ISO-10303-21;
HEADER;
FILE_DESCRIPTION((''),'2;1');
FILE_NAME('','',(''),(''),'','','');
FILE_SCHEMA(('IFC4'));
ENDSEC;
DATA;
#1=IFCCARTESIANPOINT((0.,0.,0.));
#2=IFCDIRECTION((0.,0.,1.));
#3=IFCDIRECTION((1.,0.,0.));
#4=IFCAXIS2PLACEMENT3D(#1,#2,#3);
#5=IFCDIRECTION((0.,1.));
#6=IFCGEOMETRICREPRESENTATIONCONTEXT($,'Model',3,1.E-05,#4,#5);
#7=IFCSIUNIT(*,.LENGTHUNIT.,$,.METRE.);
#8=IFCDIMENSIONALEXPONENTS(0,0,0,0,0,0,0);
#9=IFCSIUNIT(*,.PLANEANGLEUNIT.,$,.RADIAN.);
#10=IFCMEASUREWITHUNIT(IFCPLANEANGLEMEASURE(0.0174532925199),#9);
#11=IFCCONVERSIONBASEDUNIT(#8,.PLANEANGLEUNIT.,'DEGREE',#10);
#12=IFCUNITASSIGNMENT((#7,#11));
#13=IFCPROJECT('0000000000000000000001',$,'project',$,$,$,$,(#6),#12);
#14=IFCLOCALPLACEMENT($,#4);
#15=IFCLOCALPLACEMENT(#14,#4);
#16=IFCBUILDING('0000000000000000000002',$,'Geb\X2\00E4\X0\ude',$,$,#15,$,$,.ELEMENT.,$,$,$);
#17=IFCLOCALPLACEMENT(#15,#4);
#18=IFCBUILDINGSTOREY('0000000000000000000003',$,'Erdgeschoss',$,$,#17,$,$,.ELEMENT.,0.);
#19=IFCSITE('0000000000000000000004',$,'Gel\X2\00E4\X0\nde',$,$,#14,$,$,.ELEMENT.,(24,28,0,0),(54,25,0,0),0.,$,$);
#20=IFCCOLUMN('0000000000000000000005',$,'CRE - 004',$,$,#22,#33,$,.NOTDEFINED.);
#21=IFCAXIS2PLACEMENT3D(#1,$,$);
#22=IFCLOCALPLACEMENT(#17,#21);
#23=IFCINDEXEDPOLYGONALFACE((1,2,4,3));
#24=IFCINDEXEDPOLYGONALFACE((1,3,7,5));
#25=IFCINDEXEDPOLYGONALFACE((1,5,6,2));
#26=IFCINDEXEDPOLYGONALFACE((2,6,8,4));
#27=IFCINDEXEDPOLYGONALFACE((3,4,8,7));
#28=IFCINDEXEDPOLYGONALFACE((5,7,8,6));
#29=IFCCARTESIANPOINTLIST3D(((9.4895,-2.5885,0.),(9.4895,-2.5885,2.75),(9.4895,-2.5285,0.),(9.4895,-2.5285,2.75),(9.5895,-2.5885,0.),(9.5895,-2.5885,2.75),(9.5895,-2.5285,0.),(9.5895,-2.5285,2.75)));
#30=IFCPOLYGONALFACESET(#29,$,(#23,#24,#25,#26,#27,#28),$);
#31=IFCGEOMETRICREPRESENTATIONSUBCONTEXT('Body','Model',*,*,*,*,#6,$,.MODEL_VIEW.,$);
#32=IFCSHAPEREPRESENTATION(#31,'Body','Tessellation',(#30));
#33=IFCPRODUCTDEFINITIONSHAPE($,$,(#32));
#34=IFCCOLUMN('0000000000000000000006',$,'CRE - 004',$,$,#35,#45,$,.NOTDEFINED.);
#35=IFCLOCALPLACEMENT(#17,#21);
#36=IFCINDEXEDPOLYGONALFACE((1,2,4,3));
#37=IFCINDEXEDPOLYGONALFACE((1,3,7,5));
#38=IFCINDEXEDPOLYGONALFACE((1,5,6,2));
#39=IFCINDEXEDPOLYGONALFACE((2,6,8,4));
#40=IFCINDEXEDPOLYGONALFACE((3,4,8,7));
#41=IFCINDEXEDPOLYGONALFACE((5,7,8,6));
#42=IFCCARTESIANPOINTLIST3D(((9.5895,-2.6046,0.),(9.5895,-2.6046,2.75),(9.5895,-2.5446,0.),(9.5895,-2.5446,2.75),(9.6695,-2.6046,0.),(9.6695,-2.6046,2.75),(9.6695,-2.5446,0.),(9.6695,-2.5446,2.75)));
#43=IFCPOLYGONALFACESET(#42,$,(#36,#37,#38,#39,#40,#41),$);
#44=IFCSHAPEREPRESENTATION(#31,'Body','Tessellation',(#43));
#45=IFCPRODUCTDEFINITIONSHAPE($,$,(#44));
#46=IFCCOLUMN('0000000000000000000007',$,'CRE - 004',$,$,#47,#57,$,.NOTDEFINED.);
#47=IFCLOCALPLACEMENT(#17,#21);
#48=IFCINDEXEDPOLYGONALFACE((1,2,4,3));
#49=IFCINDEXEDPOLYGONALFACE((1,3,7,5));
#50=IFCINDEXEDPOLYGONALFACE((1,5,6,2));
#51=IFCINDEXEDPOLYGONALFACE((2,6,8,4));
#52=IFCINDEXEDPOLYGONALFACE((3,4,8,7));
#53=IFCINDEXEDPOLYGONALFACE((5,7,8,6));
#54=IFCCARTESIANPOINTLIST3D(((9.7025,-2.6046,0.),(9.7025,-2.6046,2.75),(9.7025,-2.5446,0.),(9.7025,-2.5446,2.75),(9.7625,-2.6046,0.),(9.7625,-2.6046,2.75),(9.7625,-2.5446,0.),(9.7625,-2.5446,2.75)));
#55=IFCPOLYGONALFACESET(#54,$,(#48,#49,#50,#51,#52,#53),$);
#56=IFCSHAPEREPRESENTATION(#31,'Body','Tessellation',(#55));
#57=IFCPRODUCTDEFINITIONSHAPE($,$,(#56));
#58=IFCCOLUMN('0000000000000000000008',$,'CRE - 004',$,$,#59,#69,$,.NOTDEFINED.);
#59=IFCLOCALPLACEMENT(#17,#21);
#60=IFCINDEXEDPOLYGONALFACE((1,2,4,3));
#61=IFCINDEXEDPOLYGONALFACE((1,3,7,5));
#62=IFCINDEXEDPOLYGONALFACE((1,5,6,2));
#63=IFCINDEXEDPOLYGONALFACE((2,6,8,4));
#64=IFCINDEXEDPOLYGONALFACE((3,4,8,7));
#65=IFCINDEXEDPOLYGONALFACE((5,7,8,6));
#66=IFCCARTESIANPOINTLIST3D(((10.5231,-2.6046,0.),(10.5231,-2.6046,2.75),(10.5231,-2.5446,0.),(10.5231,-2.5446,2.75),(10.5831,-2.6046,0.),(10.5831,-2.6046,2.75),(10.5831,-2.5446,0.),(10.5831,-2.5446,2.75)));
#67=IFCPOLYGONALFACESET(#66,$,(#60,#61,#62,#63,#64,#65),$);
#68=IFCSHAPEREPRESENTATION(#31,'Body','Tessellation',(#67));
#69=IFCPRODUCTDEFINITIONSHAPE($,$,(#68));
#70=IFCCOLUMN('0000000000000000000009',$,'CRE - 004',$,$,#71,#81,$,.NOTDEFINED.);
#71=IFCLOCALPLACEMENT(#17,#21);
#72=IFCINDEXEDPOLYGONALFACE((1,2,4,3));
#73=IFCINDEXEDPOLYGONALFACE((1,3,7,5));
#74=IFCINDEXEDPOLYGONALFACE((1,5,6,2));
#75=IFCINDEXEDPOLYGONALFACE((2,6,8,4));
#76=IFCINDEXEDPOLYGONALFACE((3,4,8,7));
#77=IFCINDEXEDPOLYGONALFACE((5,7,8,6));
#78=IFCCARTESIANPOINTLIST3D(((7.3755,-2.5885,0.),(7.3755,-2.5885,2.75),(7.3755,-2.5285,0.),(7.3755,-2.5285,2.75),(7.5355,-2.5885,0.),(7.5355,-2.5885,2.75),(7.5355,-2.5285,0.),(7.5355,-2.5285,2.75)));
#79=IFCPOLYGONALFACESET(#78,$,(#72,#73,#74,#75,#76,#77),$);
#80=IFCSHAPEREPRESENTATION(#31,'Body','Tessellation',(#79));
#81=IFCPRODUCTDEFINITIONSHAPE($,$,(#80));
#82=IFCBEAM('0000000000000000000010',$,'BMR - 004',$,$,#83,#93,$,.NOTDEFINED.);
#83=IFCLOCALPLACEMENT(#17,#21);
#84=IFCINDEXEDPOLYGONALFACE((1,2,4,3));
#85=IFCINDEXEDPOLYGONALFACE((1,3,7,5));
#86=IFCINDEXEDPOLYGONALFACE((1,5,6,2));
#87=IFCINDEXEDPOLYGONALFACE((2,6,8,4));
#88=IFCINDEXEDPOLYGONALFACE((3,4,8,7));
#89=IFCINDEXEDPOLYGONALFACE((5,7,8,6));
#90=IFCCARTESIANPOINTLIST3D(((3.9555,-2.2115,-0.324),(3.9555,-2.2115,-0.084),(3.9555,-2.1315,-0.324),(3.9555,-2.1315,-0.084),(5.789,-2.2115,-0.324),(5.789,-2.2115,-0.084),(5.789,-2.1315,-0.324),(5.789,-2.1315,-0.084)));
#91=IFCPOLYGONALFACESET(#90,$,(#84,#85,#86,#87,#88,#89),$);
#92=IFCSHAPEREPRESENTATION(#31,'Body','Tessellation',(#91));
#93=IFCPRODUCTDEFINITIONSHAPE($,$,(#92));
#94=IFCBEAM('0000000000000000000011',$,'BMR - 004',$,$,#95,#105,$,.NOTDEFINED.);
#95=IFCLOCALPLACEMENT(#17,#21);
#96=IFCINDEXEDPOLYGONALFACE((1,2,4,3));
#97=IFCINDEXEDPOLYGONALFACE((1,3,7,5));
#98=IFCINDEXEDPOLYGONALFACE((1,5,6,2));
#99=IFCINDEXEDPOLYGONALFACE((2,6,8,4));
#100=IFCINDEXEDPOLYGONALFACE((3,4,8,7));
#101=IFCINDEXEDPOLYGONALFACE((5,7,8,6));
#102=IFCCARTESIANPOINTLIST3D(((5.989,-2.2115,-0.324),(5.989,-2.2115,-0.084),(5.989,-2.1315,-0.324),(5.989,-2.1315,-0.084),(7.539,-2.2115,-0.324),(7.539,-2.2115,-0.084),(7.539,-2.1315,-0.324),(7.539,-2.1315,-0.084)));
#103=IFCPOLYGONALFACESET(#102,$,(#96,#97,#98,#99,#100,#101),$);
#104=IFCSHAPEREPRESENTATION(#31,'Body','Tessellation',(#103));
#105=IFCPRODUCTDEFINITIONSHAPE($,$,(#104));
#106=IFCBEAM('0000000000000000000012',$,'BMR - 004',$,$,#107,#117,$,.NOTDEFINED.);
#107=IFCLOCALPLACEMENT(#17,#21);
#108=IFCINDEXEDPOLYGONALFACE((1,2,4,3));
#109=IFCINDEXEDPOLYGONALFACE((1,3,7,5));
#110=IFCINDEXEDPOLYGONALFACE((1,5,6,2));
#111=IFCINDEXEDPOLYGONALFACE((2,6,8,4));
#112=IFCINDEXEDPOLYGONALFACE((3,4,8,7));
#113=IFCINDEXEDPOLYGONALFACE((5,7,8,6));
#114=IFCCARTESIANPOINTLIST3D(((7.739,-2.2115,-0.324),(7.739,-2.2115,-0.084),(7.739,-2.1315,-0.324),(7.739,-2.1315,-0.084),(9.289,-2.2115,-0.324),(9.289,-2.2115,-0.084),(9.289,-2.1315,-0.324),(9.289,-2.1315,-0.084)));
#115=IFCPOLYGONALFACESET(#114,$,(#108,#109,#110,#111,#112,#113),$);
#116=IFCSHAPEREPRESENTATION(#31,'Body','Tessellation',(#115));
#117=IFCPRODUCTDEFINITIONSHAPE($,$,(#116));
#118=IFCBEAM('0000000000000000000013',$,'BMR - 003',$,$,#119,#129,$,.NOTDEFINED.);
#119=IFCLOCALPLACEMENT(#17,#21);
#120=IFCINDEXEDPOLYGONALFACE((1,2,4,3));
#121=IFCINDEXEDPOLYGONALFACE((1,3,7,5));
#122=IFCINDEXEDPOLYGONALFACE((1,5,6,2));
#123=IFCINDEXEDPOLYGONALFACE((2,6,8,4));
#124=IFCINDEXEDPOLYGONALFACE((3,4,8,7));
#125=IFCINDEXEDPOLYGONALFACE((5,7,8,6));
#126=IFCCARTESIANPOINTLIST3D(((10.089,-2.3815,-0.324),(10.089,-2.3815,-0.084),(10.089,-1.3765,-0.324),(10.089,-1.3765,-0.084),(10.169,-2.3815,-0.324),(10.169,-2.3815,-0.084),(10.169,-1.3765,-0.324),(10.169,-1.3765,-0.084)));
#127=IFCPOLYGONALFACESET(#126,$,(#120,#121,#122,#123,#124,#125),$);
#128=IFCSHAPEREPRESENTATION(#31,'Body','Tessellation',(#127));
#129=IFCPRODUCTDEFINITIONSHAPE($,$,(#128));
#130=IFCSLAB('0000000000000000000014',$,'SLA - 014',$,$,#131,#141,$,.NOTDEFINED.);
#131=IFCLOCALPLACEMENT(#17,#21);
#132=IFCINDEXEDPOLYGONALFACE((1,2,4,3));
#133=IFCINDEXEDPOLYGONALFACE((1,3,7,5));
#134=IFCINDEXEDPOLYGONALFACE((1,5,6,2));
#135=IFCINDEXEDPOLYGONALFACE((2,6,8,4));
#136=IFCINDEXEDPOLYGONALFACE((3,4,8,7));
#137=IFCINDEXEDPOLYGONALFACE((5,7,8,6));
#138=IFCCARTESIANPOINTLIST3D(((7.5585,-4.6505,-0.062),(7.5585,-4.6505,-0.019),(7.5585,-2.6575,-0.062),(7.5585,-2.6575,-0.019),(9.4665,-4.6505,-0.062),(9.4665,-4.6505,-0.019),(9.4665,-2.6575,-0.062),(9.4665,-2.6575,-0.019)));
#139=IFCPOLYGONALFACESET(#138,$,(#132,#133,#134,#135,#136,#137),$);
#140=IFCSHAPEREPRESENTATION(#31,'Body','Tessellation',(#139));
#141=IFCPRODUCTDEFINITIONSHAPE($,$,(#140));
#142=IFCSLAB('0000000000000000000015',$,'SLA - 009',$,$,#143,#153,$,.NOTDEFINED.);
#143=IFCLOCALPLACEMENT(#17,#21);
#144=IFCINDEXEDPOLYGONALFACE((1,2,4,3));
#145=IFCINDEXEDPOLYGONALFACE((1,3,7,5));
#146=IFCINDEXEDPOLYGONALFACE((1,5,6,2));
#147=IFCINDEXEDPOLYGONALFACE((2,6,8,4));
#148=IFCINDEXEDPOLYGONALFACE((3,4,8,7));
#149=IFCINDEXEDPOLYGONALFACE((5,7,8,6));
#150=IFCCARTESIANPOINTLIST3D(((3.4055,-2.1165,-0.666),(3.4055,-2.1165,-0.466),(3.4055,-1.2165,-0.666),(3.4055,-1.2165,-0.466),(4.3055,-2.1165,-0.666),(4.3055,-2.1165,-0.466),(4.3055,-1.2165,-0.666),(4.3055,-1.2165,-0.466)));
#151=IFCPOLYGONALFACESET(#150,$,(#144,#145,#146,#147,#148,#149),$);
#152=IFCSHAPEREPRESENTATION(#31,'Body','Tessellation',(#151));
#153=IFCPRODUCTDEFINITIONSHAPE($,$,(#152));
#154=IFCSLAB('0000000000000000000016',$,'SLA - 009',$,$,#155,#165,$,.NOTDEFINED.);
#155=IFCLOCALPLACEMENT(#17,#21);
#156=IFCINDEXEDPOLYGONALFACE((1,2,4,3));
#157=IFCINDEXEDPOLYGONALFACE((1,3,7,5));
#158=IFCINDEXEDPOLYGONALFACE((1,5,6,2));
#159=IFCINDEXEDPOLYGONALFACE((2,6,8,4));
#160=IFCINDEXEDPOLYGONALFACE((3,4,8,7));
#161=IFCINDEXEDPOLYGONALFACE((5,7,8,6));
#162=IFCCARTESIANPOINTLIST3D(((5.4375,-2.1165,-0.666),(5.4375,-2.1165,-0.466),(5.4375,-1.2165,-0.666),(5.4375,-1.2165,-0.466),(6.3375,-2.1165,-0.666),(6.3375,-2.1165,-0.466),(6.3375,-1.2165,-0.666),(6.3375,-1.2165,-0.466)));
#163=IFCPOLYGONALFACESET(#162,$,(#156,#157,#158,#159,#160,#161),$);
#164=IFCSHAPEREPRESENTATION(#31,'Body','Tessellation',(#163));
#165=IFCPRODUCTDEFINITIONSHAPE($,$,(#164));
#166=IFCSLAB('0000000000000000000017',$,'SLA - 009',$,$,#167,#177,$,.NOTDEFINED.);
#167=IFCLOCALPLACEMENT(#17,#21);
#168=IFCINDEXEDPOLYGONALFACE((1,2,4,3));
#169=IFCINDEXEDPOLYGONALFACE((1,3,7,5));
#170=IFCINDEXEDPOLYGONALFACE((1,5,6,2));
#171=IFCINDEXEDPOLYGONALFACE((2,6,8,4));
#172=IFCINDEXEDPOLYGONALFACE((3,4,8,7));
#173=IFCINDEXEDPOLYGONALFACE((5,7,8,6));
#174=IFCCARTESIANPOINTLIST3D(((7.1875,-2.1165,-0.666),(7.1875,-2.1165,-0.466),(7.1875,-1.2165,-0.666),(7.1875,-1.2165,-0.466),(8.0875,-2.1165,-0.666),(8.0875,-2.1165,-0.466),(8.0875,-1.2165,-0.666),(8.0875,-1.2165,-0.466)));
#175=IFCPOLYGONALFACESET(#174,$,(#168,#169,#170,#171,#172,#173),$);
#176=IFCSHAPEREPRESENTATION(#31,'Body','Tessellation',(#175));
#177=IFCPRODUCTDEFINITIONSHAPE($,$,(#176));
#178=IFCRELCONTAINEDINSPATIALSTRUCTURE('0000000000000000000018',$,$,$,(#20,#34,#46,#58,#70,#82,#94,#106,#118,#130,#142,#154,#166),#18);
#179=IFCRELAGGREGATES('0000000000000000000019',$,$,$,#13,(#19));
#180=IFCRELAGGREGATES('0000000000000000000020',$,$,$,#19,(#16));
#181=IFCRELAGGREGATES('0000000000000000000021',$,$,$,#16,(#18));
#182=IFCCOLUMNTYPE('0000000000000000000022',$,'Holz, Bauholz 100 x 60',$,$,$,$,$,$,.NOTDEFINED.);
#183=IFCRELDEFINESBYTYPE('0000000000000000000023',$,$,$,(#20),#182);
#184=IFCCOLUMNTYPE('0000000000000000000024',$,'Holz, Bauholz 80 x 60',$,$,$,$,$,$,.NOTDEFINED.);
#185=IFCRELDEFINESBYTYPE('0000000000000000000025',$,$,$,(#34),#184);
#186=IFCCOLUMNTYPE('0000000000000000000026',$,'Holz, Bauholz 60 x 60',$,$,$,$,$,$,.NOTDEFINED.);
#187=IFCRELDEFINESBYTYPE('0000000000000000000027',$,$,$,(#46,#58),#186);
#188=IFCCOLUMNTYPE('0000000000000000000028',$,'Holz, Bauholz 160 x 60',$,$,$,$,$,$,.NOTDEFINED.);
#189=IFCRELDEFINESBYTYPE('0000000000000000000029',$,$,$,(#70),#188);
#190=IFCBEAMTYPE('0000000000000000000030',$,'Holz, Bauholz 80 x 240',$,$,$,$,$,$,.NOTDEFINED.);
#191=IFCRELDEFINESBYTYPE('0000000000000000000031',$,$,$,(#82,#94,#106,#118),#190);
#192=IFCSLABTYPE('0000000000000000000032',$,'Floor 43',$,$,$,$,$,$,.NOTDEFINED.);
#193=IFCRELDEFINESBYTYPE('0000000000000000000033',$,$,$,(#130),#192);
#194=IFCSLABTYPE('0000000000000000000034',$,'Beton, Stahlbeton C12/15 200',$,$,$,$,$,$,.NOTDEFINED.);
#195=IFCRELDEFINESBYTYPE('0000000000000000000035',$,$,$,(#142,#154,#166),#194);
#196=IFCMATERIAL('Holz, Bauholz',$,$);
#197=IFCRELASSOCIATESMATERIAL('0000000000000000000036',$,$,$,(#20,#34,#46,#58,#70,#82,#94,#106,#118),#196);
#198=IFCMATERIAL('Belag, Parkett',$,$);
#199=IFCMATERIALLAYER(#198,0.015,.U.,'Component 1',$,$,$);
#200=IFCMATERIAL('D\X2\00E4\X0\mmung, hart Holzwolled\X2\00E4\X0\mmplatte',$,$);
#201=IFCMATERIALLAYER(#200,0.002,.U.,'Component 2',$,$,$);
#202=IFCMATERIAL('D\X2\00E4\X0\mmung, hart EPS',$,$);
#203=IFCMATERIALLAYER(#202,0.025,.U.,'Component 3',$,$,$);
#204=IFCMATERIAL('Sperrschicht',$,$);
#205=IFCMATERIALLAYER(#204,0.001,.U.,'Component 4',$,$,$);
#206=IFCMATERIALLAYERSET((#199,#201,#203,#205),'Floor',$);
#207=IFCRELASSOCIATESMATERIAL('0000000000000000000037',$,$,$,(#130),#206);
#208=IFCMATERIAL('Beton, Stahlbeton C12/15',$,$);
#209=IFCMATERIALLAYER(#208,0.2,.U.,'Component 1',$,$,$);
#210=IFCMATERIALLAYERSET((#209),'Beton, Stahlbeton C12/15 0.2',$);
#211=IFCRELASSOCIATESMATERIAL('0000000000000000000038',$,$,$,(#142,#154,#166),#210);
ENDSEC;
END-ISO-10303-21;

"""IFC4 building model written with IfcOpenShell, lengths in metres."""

from ifc_helpers import new_model, entity, si_unit, converted_unit, direction, frame, frame_2d, origin_with_axes, origin_2d_with_axis, place, context, subcontext, project, spatial, line, indexed_curve, rectangle, outline, extrude, material, layer, layer_set, layer_usage, type_object, element, save


model = new_model("IFC4")

# Units and contexts
model_context = context("Model", 3, precision=1e-05, world=origin_with_axes(), true_north=direction((0.0, 1.0)))
body_context = subcontext(model_context, "Body", "Model", "MODEL_VIEW")
ifc_project = project(units=[si_unit("LENGTHUNIT", "METRE"), converted_unit("PLANEANGLEUNIT", "DEGREE", entity("IfcPlaneAngleMeasure", 0.0174532925199), si_unit("PLANEANGLEUNIT", "RADIAN"), dimensions=[0, 0, 0, 0, 0, 0, 0])], contexts=[model_context])

# Site, building, storey
site_placement = place(None, origin_with_axes())
site = spatial("IfcSite", under=ifc_project, at=site_placement, Name="Gelände", CompositionType="ELEMENT", RefLatitude=(24, 28, 0, 0), RefLongitude=(54, 25, 0, 0), RefElevation=0.0)
building_placement = place(site_placement, origin_with_axes())
building = spatial("IfcBuilding", under=site, at=building_placement, Name="Gebäude", CompositionType="ELEMENT")
storey_placement = place(building_placement, origin_with_axes())
storey = spatial("IfcBuildingStorey", under=building, at=storey_placement, Name="Erdgeschoss", CompositionType="ELEMENT", Elevation=0.0)

# Columns
ifc_material_1 = material(Name="Holz, Bauholz")
column_type_1 = type_object("IfcColumnType", Name="Holz, Bauholz 100 x 60", PredefinedType="NOTDEFINED")
column_1_placement = place(storey_placement, frame((9.5395, -2.5585, 0.0), z_axis=(0.0, 0.0, 1.0), x_axis=(0.0, -1.0, 0.0)))
element("IfcColumn", 1, at=column_1_placement, inside=storey, type_object=column_type_1, material=ifc_material_1, Name="CRE - 004", PredefinedType="NOTDEFINED", context=body_context, shape_type="SweptSolid", body=[
    extrude(rectangle(XDim=0.1, YDim=0.06, at=origin_2d_with_axis()), frame((0.0, 0.0, 0.0), z_axis=(0.0, 0.0, 1.0), x_axis=(0.0, 1.0, 0.0)), (0.0, 0.0, 1.0), 2.75),
])
column_type_2 = type_object("IfcColumnType", Name="Holz, Bauholz 80 x 60", PredefinedType="NOTDEFINED")
column_2_placement = place(storey_placement, frame((9.6295, -2.5746, 0.0), z_axis=(0.0, 0.0, 1.0), x_axis=(0.0, -1.0, 0.0)))
element("IfcColumn", 2, at=column_2_placement, inside=storey, type_object=column_type_2, material=ifc_material_1, Name="CRE - 004", PredefinedType="NOTDEFINED", context=body_context, shape_type="SweptSolid", body=[
    extrude(rectangle(XDim=0.08, YDim=0.06, at=origin_2d_with_axis()), frame((0.0, 0.0, 0.0), z_axis=(0.0, 0.0, 1.0), x_axis=(0.0, 1.0, 0.0)), (0.0, 0.0, 1.0), 2.75),
])
column_type_3 = type_object("IfcColumnType", Name="Holz, Bauholz 60 x 60", PredefinedType="NOTDEFINED")
for number, where, z_axis, x_axis, name in (
    (3, (9.7325, -2.5746, 0.0), (0.0, 0.0, 1.0), (0.0, -1.0, 0.0), "CRE - 004"),
    (4, (10.5531, -2.5746, 0.0), (0.0, 0.0, 1.0), (0.0, -1.0, 0.0), "CRE - 004"),
):
    element("IfcColumn", number, at=place(storey_placement, frame(where, z_axis=z_axis, x_axis=x_axis)), inside=storey, type_object=column_type_3, material=ifc_material_1, Name=name, PredefinedType="NOTDEFINED", context=body_context, shape_type="SweptSolid", body=[
        extrude(rectangle(XDim=0.06, YDim=0.06, at=origin_2d_with_axis()), frame((0.0, 0.0, 0.0), z_axis=(0.0, 0.0, 1.0), x_axis=(0.0, 1.0, 0.0)), (0.0, 0.0, 1.0), 2.75),
    ])
column_type_4 = type_object("IfcColumnType", Name="Holz, Bauholz 160 x 60", PredefinedType="NOTDEFINED")
column_3_placement = place(storey_placement, frame((7.4555, -2.5585, 0.0), z_axis=(0.0, 0.0, 1.0), x_axis=(0.0, -1.0, 0.0)))
element("IfcColumn", 5, at=column_3_placement, inside=storey, type_object=column_type_4, material=ifc_material_1, Name="CRE - 004", PredefinedType="NOTDEFINED", context=body_context, shape_type="SweptSolid", body=[
    extrude(rectangle(XDim=0.16, YDim=0.06, at=origin_2d_with_axis()), frame((0.0, 0.0, 0.0), z_axis=(0.0, 0.0, 1.0), x_axis=(0.0, 1.0, 0.0)), (0.0, 0.0, 1.0), 2.75),
])

# Beams
beam_type = type_object("IfcBeamType", Name="Holz, Bauholz 80 x 240", PredefinedType="NOTDEFINED")
beam_1_placement = place(storey_placement, frame((5.789, -2.1715, -0.084), z_axis=(0.0, 0.0, 1.0), x_axis=(0.0, 1.0, 0.0)))
element("IfcBeam", 6, at=beam_1_placement, inside=storey, type_object=beam_type, material=ifc_material_1, Name="BMR - 004", PredefinedType="NOTDEFINED", context=body_context, shape_type="SweptSolid", body=[
    extrude(rectangle(XDim=0.24, YDim=0.08, at=frame_2d((-0.12, 0.0), x_axis=(1.0, 0.0))), frame((0.0, 0.0, 0.0), z_axis=(0.0, 1.0, 0.0), x_axis=(0.0, 0.0, 1.0)), (0.0, 0.0, 1.0), 1.8335),
])
for number, where, z_axis, x_axis, name in (
    (7, (7.539, -2.1715, -0.084), (0.0, 0.0, 1.0), (0.0, 1.0, 0.0), "BMR - 004"),
    (8, (9.289, -2.1715, -0.084), (0.0, 0.0, 1.0), (0.0, 1.0, 0.0), "BMR - 004"),
):
    element("IfcBeam", number, at=place(storey_placement, frame(where, z_axis=z_axis, x_axis=x_axis)), inside=storey, type_object=beam_type, material=ifc_material_1, Name=name, PredefinedType="NOTDEFINED", context=body_context, shape_type="SweptSolid", body=[
        extrude(rectangle(XDim=0.24, YDim=0.08, at=frame_2d((-0.12, 0.0), x_axis=(1.0, 0.0))), frame((0.0, 0.0, 0.0), z_axis=(0.0, 1.0, 0.0), x_axis=(0.0, 0.0, 1.0)), (0.0, 0.0, 1.0), 1.55),
    ])
beam_2_placement = place(storey_placement, frame((10.129, -2.3815, -0.084), z_axis=(0.0, 0.0, 1.0), x_axis=(1.0, 0.0, 0.0)))
element("IfcBeam", 9, at=beam_2_placement, inside=storey, type_object=beam_type, material=ifc_material_1, Name="BMR - 003", PredefinedType="NOTDEFINED", context=body_context, shape_type="SweptSolid", body=[
    extrude(rectangle(XDim=0.24, YDim=0.08, at=frame_2d((-0.12, 0.0), x_axis=(1.0, 0.0))), frame((0.0, 0.0, 0.0), z_axis=(0.0, 1.0, 0.0), x_axis=(0.0, 0.0, 1.0)), (0.0, 0.0, 1.0), 1.005),
])

# Slabs
ifc_material_2 = material(Name="Belag, Parkett")
ifc_layer_1 = layer(ifc_material_2, 0.015, ventilated="UNKNOWN", Name="Component 1")
ifc_material_3 = material(Name="Dämmung, hart Holzwolledämmplatte")
ifc_layer_2 = layer(ifc_material_3, 0.002, ventilated="UNKNOWN", Name="Component 2")
ifc_material_4 = material(Name="Dämmung, hart EPS")
ifc_layer_3 = layer(ifc_material_4, 0.025, ventilated="UNKNOWN", Name="Component 3")
ifc_material_5 = material(Name="Sperrschicht")
ifc_layer_4 = layer(ifc_material_5, 0.001, ventilated="UNKNOWN", Name="Component 4")
ifc_layer_set_1 = layer_set([ifc_layer_1, ifc_layer_2, ifc_layer_3, ifc_layer_4], Name="Floor")
ifc_layer_usage_1 = layer_usage(ifc_layer_set_1, "AXIS3", "NEGATIVE", 0.043)
slab_type_1 = type_object("IfcSlabType", Name="Floor 43", PredefinedType="NOTDEFINED")
slab_1_placement = place(storey_placement, frame((7.5585, -2.6575, -0.019), z_axis=(0.0, 0.0, 1.0), x_axis=(1.0, 0.0, 0.0)))
element("IfcSlab", 10, at=slab_1_placement, inside=storey, type_object=slab_type_1, material=ifc_layer_usage_1, Name="SLA - 014", PredefinedType="NOTDEFINED", context=body_context, shape_type="SweptSolid", body=[
    extrude(outline(indexed_curve([(0.0, 0.0), (0.0, -1.993), (1.908, -1.993), (1.908, 0.0)], segments=[line(1, 2, 3, 4, 1)])), frame((0.0, 0.0, -0.043), z_axis=(0.0, 0.0, 1.0), x_axis=(1.0, 0.0, 0.0)), (0.0, 0.0, 1.0), 0.043),
])
ifc_material_6 = material(Name="Beton, Stahlbeton C12/15")
ifc_layer_5 = layer(ifc_material_6, 0.2, ventilated="UNKNOWN", Name="Component 1")
ifc_layer_set_2 = layer_set([ifc_layer_5], Name="Beton, Stahlbeton C12/15 0.2")
ifc_layer_usage_2 = layer_usage(ifc_layer_set_2, "AXIS3", "NEGATIVE", 0.2)
slab_type_2 = type_object("IfcSlabType", Name="Beton, Stahlbeton C12/15 200", PredefinedType="NOTDEFINED")
slab_2_placement = place(storey_placement, frame((3.4055, -2.1165, -0.466), z_axis=(0.0, 0.0, 1.0), x_axis=(1.0, 0.0, 0.0)))
element("IfcSlab", 11, at=slab_2_placement, inside=storey, type_object=slab_type_2, material=ifc_layer_usage_2, Name="SLA - 009", PredefinedType="NOTDEFINED", context=body_context, shape_type="SweptSolid", body=[
    extrude(outline(indexed_curve([(0.0, 0.0), (0.9, 0.0), (0.9, 0.9), (0.0, 0.9)], segments=[line(1, 2, 3, 4, 1)])), frame((0.0, 0.0, -0.2), z_axis=(0.0, 0.0, 1.0), x_axis=(1.0, 0.0, 0.0)), (0.0, 0.0, 1.0), 0.2),
])
ifc_layer_usage_3 = layer_usage(ifc_layer_set_2, "AXIS3", "NEGATIVE", 0.2)
slab_3_placement = place(storey_placement, frame((5.4375, -2.1165, -0.466), z_axis=(0.0, 0.0, 1.0), x_axis=(1.0, 0.0, 0.0)))
element("IfcSlab", 12, at=slab_3_placement, inside=storey, type_object=slab_type_2, material=ifc_layer_usage_3, Name="SLA - 009", PredefinedType="NOTDEFINED", context=body_context, shape_type="SweptSolid", body=[
    extrude(outline(indexed_curve([(0.0, 0.0), (0.9, 0.0), (0.9, 0.9), (0.0, 0.9)], segments=[line(1, 2, 3, 4, 1)])), frame((0.0, 0.0, -0.2), z_axis=(0.0, 0.0, 1.0), x_axis=(1.0, 0.0, 0.0)), (0.0, 0.0, 1.0), 0.2),
])
ifc_layer_usage_4 = layer_usage(ifc_layer_set_2, "AXIS3", "NEGATIVE", 0.2)
slab_4_placement = place(storey_placement, frame((7.1875, -2.1165, -0.466), z_axis=(0.0, 0.0, 1.0), x_axis=(1.0, 0.0, 0.0)))
element("IfcSlab", 13, at=slab_4_placement, inside=storey, type_object=slab_type_2, material=ifc_layer_usage_4, Name="SLA - 009", PredefinedType="NOTDEFINED", context=body_context, shape_type="SweptSolid", body=[
    extrude(outline(indexed_curve([(0.0, 0.0), (0.9, 0.0), (0.9, 0.9), (0.0, 0.9)], segments=[line(1, 2, 3, 4, 1)])), frame((0.0, 0.0, -0.2), z_axis=(0.0, 0.0, 1.0), x_axis=(1.0, 0.0, 0.0)), (0.0, 0.0, 1.0), 0.2),
])

save(model, "model.ifc")
